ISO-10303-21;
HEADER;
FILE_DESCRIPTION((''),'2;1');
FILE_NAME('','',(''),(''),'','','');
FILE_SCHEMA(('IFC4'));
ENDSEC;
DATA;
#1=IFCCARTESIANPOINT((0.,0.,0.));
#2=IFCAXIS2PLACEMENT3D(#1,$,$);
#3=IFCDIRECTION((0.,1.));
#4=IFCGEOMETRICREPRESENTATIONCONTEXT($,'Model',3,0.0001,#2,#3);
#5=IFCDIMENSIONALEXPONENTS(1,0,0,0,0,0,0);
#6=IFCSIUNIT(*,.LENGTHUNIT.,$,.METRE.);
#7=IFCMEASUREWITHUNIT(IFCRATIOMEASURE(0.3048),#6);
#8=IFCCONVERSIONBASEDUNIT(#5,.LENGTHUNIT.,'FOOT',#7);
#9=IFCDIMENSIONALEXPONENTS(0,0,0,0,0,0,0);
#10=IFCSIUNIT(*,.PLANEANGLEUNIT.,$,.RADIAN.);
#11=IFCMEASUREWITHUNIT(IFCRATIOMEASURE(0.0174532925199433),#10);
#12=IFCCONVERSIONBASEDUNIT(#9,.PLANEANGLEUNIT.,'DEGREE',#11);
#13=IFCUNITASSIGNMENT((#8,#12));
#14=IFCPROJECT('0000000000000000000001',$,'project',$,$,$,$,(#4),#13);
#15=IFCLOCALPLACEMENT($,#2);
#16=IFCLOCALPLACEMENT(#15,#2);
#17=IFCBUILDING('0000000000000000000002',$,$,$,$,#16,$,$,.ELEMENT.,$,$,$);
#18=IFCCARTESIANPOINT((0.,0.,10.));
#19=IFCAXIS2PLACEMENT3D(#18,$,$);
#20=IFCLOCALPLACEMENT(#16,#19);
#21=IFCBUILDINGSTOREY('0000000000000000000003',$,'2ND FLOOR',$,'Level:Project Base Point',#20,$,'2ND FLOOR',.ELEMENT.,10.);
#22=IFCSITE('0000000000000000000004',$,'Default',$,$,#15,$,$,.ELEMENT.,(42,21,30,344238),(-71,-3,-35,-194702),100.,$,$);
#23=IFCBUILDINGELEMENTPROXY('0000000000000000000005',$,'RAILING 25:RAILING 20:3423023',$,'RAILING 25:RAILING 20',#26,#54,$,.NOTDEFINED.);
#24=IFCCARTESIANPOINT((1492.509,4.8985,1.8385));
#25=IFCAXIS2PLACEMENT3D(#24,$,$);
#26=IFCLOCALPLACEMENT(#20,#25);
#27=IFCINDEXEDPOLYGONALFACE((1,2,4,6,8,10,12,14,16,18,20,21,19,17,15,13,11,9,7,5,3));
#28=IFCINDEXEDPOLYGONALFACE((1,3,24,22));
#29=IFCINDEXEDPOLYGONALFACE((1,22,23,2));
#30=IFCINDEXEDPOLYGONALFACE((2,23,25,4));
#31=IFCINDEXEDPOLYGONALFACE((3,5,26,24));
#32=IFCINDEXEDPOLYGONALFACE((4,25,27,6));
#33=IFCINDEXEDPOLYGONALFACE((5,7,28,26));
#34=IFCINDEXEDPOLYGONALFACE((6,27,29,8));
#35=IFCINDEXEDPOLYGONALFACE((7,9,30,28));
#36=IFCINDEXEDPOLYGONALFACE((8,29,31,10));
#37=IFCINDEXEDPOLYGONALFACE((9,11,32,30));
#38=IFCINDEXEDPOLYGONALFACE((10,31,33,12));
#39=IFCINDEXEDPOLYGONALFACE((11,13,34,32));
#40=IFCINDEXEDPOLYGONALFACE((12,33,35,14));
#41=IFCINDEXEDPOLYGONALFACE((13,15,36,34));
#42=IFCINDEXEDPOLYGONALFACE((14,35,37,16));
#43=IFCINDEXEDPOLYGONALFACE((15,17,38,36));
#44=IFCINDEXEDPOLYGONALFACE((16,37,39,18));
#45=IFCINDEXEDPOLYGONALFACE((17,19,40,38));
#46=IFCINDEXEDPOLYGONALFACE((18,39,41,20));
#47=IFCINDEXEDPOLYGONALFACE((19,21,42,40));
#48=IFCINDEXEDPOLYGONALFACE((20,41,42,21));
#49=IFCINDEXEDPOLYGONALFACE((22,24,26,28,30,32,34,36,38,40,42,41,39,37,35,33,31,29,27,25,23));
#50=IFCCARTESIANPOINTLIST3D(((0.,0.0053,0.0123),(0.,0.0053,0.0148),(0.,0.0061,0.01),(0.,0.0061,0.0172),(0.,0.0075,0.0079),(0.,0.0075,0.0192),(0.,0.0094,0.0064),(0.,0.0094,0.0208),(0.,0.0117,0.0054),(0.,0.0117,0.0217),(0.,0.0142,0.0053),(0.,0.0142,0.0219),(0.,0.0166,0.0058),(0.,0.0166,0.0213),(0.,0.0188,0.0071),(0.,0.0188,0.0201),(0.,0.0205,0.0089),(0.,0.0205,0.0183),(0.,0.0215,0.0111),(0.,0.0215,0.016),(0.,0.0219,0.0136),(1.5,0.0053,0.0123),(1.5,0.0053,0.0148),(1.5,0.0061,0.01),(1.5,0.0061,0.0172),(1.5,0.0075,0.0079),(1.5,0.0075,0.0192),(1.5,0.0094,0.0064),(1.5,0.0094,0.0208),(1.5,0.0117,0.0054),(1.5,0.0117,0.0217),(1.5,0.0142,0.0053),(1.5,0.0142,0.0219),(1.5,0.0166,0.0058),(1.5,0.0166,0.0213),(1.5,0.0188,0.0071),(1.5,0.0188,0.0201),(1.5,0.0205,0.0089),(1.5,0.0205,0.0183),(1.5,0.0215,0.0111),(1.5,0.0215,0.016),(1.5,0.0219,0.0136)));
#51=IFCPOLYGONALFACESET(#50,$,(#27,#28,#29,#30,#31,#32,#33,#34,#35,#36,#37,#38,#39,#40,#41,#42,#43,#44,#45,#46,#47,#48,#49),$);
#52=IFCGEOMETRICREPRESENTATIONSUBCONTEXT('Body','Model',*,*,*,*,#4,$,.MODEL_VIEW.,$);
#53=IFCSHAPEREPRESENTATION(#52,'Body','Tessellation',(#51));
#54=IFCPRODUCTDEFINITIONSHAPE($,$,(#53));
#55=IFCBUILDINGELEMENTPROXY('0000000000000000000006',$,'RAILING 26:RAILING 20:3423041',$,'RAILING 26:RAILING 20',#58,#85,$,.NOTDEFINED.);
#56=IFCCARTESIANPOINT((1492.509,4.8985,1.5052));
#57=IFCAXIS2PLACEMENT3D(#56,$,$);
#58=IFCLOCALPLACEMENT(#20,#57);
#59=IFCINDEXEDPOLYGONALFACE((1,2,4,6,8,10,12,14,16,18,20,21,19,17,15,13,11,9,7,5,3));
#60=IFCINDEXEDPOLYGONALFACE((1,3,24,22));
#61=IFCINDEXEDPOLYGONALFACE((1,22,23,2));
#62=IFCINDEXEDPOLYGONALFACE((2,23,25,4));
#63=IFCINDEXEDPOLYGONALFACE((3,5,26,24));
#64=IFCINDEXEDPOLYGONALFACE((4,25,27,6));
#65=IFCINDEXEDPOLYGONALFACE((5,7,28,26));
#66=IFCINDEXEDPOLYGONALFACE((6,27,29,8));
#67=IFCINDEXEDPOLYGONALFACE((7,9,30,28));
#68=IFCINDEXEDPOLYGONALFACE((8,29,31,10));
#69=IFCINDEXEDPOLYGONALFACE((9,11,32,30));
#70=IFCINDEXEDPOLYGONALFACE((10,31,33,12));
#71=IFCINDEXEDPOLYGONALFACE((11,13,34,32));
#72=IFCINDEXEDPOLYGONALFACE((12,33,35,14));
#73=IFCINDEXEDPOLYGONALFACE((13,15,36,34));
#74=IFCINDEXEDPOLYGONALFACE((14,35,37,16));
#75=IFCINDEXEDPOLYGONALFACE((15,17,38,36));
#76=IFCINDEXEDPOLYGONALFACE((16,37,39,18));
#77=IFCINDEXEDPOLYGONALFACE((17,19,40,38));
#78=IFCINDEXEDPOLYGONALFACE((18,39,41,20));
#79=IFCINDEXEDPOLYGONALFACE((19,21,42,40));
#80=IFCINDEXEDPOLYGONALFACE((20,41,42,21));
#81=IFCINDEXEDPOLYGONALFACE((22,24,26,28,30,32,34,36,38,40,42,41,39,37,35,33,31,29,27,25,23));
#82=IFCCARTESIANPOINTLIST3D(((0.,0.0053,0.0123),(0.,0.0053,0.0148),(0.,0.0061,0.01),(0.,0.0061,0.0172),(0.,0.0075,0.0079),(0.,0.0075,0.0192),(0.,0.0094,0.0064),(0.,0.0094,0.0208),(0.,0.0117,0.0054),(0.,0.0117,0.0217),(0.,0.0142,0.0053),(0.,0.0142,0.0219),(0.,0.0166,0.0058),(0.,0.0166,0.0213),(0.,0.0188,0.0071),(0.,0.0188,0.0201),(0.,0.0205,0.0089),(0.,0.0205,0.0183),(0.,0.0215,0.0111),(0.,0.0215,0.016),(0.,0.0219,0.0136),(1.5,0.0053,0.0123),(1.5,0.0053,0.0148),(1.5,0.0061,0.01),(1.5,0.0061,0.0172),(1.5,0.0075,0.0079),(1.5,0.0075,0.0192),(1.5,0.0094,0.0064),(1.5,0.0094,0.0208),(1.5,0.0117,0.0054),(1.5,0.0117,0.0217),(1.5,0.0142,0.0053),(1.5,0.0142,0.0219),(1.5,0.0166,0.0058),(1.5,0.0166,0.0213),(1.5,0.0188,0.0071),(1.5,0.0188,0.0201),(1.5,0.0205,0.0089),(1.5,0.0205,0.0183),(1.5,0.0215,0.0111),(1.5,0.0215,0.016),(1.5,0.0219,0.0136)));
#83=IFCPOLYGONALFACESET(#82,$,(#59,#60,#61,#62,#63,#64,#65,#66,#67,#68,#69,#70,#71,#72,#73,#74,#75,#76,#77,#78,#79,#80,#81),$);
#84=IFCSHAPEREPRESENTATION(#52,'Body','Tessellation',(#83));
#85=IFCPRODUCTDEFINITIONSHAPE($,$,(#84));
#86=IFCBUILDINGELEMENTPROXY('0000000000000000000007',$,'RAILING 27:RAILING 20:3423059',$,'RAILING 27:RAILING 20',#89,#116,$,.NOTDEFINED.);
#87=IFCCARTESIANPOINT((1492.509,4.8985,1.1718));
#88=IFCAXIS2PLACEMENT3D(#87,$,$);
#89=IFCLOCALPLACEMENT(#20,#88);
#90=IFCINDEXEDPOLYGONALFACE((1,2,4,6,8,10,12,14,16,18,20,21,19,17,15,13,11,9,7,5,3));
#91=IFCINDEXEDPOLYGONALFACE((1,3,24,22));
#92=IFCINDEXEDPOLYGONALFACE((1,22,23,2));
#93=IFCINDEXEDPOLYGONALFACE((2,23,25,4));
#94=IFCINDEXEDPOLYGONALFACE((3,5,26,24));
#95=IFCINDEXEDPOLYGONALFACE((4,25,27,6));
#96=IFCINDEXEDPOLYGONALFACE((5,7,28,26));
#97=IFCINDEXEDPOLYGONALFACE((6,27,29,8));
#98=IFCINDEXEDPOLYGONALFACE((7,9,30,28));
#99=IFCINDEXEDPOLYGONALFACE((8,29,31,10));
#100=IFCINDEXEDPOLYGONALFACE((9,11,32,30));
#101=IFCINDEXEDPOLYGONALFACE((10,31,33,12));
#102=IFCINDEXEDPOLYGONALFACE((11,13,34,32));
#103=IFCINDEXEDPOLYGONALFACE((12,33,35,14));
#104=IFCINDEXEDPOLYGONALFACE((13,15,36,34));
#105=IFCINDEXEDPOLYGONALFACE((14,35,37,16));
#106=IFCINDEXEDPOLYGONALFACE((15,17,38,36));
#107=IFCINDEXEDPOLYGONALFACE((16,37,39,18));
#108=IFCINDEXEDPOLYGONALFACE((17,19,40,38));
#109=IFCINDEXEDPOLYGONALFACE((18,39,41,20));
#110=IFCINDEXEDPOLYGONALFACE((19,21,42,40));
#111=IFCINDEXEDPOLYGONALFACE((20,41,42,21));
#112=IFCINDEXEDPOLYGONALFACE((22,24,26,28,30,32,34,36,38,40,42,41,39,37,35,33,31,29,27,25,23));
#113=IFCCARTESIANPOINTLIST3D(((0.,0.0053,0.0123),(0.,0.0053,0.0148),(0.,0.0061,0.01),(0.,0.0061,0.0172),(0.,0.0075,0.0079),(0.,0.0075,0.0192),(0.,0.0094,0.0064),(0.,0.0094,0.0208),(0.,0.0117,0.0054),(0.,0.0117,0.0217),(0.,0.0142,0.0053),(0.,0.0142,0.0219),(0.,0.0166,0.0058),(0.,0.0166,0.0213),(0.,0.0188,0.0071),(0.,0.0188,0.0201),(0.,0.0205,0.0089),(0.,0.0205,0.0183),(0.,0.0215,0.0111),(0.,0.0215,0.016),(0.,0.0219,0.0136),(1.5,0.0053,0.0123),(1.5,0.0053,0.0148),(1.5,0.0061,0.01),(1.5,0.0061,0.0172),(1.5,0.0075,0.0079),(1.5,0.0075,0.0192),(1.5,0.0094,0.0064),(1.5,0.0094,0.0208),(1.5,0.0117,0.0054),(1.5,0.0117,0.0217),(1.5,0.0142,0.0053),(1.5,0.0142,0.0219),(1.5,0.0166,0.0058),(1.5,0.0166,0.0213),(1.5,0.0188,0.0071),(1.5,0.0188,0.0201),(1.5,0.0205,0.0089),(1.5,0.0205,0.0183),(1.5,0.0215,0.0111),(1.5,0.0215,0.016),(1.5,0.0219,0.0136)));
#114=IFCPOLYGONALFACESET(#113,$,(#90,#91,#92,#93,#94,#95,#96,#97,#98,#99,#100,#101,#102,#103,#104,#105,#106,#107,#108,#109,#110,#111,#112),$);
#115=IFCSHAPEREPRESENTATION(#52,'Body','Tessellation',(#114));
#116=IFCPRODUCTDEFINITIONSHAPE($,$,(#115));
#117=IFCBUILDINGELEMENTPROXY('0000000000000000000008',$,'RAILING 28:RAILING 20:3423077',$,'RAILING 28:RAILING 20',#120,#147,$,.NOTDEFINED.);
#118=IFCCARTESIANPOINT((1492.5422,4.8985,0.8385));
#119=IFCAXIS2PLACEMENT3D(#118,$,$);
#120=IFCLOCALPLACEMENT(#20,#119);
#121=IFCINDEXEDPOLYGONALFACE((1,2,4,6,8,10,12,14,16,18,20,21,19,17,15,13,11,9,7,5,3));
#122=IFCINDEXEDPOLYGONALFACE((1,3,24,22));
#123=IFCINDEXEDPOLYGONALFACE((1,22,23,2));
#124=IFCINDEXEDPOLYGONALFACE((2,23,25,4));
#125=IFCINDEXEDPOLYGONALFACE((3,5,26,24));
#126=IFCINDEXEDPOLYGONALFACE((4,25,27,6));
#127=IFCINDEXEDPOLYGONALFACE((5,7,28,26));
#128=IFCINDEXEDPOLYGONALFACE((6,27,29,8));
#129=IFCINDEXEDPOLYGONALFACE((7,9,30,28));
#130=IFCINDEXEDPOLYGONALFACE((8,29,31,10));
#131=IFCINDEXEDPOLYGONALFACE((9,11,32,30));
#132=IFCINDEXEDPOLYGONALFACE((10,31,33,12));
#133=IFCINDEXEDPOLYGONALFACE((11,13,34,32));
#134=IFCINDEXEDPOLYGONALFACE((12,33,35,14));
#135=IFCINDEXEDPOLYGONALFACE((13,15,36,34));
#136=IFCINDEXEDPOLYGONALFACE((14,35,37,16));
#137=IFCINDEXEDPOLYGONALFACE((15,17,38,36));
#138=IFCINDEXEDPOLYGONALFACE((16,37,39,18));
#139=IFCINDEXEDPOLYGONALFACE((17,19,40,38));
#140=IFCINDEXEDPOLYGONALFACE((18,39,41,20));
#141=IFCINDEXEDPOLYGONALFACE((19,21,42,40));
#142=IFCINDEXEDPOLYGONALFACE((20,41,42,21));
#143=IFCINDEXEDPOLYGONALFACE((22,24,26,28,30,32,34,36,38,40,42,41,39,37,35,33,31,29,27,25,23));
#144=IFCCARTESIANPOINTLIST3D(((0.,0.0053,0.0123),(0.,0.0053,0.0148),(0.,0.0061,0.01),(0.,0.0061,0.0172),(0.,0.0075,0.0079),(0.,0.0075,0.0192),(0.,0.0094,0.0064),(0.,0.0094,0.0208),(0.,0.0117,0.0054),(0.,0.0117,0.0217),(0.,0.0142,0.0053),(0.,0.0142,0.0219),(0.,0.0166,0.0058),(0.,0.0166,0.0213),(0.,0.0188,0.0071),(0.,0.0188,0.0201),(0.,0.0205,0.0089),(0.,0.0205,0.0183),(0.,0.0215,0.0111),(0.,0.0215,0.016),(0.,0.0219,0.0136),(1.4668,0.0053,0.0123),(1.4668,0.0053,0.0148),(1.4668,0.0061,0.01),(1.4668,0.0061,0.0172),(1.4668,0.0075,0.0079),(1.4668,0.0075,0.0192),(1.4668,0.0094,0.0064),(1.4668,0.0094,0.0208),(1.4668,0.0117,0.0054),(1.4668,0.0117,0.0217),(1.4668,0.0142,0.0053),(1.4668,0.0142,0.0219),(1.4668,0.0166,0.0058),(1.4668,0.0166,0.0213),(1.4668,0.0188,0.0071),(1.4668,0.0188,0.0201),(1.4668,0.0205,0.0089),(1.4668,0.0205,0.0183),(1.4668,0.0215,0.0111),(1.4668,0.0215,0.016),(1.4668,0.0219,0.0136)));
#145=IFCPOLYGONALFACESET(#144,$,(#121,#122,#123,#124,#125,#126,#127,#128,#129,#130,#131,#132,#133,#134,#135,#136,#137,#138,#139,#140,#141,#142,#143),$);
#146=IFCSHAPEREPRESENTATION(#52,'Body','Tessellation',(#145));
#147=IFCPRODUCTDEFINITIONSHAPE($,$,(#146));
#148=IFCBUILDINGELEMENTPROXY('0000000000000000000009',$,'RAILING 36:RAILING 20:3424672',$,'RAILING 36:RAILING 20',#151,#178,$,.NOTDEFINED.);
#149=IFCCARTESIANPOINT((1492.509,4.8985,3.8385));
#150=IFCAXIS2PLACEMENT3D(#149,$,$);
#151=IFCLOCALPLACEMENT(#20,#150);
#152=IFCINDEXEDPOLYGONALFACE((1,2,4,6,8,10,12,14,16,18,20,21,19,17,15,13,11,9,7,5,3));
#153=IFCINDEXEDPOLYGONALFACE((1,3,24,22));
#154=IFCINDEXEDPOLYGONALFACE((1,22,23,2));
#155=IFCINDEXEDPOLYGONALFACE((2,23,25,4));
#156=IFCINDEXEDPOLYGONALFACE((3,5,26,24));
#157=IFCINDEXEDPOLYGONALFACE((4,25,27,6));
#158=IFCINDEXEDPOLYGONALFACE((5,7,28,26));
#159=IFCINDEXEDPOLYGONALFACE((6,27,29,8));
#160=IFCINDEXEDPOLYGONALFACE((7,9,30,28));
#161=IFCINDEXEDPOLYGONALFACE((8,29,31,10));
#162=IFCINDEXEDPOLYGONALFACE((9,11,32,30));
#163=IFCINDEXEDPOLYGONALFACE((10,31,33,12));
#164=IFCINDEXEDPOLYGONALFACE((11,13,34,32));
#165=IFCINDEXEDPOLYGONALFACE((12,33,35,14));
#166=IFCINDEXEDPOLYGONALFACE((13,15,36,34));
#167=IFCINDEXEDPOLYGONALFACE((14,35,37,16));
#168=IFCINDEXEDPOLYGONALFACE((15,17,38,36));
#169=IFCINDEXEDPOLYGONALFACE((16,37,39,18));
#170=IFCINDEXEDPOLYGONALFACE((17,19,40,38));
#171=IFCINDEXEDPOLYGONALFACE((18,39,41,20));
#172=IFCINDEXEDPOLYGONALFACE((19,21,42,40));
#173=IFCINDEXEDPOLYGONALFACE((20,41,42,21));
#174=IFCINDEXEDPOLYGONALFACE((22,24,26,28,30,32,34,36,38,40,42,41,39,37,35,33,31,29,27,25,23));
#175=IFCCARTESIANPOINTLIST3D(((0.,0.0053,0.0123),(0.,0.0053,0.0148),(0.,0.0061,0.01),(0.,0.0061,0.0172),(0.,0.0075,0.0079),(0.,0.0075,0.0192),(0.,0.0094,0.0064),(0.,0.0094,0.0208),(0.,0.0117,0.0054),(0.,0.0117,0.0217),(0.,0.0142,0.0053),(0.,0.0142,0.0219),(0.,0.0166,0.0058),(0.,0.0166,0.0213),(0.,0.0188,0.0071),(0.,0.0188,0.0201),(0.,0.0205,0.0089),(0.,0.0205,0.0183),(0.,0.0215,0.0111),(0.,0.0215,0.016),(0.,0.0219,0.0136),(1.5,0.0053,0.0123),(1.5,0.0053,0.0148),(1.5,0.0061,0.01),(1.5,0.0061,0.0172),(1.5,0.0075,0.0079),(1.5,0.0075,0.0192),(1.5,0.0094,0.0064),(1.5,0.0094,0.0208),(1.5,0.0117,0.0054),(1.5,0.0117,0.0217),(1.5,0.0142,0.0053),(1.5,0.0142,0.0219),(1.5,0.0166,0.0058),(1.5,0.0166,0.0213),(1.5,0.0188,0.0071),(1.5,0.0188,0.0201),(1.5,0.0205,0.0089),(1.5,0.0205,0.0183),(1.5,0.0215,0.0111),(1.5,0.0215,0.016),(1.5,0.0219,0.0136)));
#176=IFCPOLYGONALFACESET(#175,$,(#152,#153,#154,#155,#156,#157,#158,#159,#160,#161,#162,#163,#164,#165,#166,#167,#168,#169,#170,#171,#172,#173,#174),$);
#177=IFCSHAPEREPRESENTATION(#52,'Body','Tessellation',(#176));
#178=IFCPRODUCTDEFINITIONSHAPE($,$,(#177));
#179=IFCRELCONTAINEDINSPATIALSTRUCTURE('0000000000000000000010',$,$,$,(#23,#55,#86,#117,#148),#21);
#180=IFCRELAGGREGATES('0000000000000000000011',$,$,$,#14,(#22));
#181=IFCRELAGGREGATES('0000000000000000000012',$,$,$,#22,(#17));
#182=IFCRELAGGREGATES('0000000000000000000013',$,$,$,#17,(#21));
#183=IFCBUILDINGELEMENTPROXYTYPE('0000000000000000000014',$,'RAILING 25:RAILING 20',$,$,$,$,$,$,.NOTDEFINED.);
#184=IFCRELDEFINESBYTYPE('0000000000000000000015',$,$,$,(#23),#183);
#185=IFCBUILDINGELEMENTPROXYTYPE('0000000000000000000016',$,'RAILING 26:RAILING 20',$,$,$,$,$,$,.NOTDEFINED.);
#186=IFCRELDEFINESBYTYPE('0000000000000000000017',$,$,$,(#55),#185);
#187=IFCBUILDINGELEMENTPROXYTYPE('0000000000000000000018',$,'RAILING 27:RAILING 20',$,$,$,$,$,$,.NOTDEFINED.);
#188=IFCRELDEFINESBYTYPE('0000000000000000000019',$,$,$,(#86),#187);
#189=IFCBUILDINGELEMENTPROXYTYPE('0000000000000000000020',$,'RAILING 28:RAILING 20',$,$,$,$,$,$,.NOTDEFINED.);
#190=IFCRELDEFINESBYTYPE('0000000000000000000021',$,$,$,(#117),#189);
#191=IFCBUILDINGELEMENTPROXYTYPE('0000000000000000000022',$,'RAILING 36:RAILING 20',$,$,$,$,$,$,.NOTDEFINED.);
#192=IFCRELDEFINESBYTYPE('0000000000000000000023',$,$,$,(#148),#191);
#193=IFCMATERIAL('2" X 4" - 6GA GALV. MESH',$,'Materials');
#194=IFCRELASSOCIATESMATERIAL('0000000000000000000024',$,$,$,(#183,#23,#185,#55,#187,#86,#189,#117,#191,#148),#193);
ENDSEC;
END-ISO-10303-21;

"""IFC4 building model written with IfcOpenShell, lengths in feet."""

from ifc_helpers import new_model, entity, si_unit, converted_unit, direction, frame, origin, origin_2d_with_axis, place, context, subcontext, project, spatial, circle, extrude, source, transform, mapped, material, type_object, type_shapes, element, save


model = new_model("IFC4")

# Units and contexts
model_context = context("Model", 3, precision=0.0001, world=origin(), true_north=direction((0.0, 1.0)))
body_context = subcontext(model_context, "Body", "Model", "MODEL_VIEW")
ifc_project = project(units=[converted_unit("LENGTHUNIT", "FOOT", entity("IfcRatioMeasure", 0.3048), si_unit("LENGTHUNIT", "METRE"), dimensions=[1, 0, 0, 0, 0, 0, 0]), converted_unit("PLANEANGLEUNIT", "DEGREE", entity("IfcRatioMeasure", 0.0174532925199433), si_unit("PLANEANGLEUNIT", "RADIAN"), dimensions=[0, 0, 0, 0, 0, 0, 0])], contexts=[model_context])

# Site, building, storey
site_placement = place(None, origin())
site = spatial("IfcSite", under=ifc_project, at=site_placement, Name="Default", CompositionType="ELEMENT", RefLatitude=(42, 21, 30, 344238), RefLongitude=(-71, -3, -35, -194702), RefElevation=100.0)
building_placement = place(site_placement, origin())
building = spatial("IfcBuilding", under=site, at=building_placement, CompositionType="ELEMENT")
storey_placement = place(building_placement, frame((0.0, 0.0, 10.0)))
storey = spatial("IfcBuildingStorey", under=building, at=storey_placement, Name="2ND FLOOR", ObjectType="Level:Project Base Point", LongName="2ND FLOOR", CompositionType="ELEMENT", Elevation=10.0)

# Building element proxies
ifc_material_1 = material(Name="2\" X 4\" - 6GA GALV. MESH", Category="Materials")
building_element_proxy_type_1 = type_object("IfcBuildingElementProxyType", Name="RAILING 25:RAILING 20", PredefinedType="NOTDEFINED", material=ifc_material_1)
shared_shape_1 = source(origin(), body_context, "Body", "SweptSolid", [
    extrude(circle(Radius=0.0083, at=origin_2d_with_axis()), frame((0.0, 0.0136, 0.0136), z_axis=(1.0, 0.0, 0.0), x_axis=(0.0, 1.0, 0.0)), (0.0, 0.0, 1.0), 1.5),
])
type_shapes(building_element_proxy_type_1, [shared_shape_1])
proxy_1_placement = place(storey_placement, frame((1492.509, 4.8985, 1.8385)))
element("IfcBuildingElementProxy", 1, at=proxy_1_placement, inside=storey, type_object=building_element_proxy_type_1, material=ifc_material_1, Name="RAILING 25:RAILING 20:3423023", ObjectType="RAILING 25:RAILING 20", PredefinedType="NOTDEFINED", context=body_context, shape_type="MappedRepresentation", body=[
    mapped(shared_shape_1, transform((0.0, 0.0, 0.0), scale=1.0)),
])
building_element_proxy_type_2 = type_object("IfcBuildingElementProxyType", Name="RAILING 26:RAILING 20", PredefinedType="NOTDEFINED", material=ifc_material_1)
shared_shape_2 = source(origin(), body_context, "Body", "SweptSolid", [
    extrude(circle(Radius=0.0083, at=origin_2d_with_axis()), frame((0.0, 0.0136, 0.0136), z_axis=(1.0, 0.0, 0.0), x_axis=(0.0, 1.0, 0.0)), (0.0, 0.0, 1.0), 1.5),
])
type_shapes(building_element_proxy_type_2, [shared_shape_2])
proxy_2_placement = place(storey_placement, frame((1492.509, 4.8985, 1.5052)))
element("IfcBuildingElementProxy", 2, at=proxy_2_placement, inside=storey, type_object=building_element_proxy_type_2, material=ifc_material_1, Name="RAILING 26:RAILING 20:3423041", ObjectType="RAILING 26:RAILING 20", PredefinedType="NOTDEFINED", context=body_context, shape_type="MappedRepresentation", body=[
    mapped(shared_shape_2, transform((0.0, 0.0, 0.0), scale=1.0)),
])
building_element_proxy_type_3 = type_object("IfcBuildingElementProxyType", Name="RAILING 27:RAILING 20", PredefinedType="NOTDEFINED", material=ifc_material_1)
shared_shape_3 = source(origin(), body_context, "Body", "SweptSolid", [
    extrude(circle(Radius=0.0083, at=origin_2d_with_axis()), frame((0.0, 0.0136, 0.0136), z_axis=(1.0, 0.0, 0.0), x_axis=(0.0, 1.0, 0.0)), (0.0, 0.0, 1.0), 1.5),
])
type_shapes(building_element_proxy_type_3, [shared_shape_3])
proxy_3_placement = place(storey_placement, frame((1492.509, 4.8985, 1.1718)))
element("IfcBuildingElementProxy", 3, at=proxy_3_placement, inside=storey, type_object=building_element_proxy_type_3, material=ifc_material_1, Name="RAILING 27:RAILING 20:3423059", ObjectType="RAILING 27:RAILING 20", PredefinedType="NOTDEFINED", context=body_context, shape_type="MappedRepresentation", body=[
    mapped(shared_shape_3, transform((0.0, 0.0, 0.0), scale=1.0)),
])
building_element_proxy_type_4 = type_object("IfcBuildingElementProxyType", Name="RAILING 28:RAILING 20", PredefinedType="NOTDEFINED", material=ifc_material_1)
shared_shape_4 = source(origin(), body_context, "Body", "SweptSolid", [
    extrude(circle(Radius=0.0083, at=origin_2d_with_axis()), frame((0.0, 0.0136, 0.0136), z_axis=(1.0, 0.0, 0.0), x_axis=(0.0, 1.0, 0.0)), (0.0, 0.0, 1.0), 1.4668),
])
type_shapes(building_element_proxy_type_4, [shared_shape_4])
proxy_4_placement = place(storey_placement, frame((1492.5422, 4.8985, 0.8385)))
element("IfcBuildingElementProxy", 4, at=proxy_4_placement, inside=storey, type_object=building_element_proxy_type_4, material=ifc_material_1, Name="RAILING 28:RAILING 20:3423077", ObjectType="RAILING 28:RAILING 20", PredefinedType="NOTDEFINED", context=body_context, shape_type="MappedRepresentation", body=[
    mapped(shared_shape_4, transform((0.0, 0.0, 0.0), scale=1.0)),
])
building_element_proxy_type_5 = type_object("IfcBuildingElementProxyType", Name="RAILING 36:RAILING 20", PredefinedType="NOTDEFINED", material=ifc_material_1)
shared_shape_5 = source(origin(), body_context, "Body", "SweptSolid", [
    extrude(circle(Radius=0.0083, at=origin_2d_with_axis()), frame((0.0, 0.0136, 0.0136), z_axis=(1.0, 0.0, 0.0), x_axis=(0.0, 1.0, 0.0)), (0.0, 0.0, 1.0), 1.5),
])
type_shapes(building_element_proxy_type_5, [shared_shape_5])
proxy_5_placement = place(storey_placement, frame((1492.509, 4.8985, 3.8385)))
element("IfcBuildingElementProxy", 5, at=proxy_5_placement, inside=storey, type_object=building_element_proxy_type_5, material=ifc_material_1, Name="RAILING 36:RAILING 20:3424672", ObjectType="RAILING 36:RAILING 20", PredefinedType="NOTDEFINED", context=body_context, shape_type="MappedRepresentation", body=[
    mapped(shared_shape_5, transform((0.0, 0.0, 0.0), scale=1.0)),
])

save(model, "model.ifc")
